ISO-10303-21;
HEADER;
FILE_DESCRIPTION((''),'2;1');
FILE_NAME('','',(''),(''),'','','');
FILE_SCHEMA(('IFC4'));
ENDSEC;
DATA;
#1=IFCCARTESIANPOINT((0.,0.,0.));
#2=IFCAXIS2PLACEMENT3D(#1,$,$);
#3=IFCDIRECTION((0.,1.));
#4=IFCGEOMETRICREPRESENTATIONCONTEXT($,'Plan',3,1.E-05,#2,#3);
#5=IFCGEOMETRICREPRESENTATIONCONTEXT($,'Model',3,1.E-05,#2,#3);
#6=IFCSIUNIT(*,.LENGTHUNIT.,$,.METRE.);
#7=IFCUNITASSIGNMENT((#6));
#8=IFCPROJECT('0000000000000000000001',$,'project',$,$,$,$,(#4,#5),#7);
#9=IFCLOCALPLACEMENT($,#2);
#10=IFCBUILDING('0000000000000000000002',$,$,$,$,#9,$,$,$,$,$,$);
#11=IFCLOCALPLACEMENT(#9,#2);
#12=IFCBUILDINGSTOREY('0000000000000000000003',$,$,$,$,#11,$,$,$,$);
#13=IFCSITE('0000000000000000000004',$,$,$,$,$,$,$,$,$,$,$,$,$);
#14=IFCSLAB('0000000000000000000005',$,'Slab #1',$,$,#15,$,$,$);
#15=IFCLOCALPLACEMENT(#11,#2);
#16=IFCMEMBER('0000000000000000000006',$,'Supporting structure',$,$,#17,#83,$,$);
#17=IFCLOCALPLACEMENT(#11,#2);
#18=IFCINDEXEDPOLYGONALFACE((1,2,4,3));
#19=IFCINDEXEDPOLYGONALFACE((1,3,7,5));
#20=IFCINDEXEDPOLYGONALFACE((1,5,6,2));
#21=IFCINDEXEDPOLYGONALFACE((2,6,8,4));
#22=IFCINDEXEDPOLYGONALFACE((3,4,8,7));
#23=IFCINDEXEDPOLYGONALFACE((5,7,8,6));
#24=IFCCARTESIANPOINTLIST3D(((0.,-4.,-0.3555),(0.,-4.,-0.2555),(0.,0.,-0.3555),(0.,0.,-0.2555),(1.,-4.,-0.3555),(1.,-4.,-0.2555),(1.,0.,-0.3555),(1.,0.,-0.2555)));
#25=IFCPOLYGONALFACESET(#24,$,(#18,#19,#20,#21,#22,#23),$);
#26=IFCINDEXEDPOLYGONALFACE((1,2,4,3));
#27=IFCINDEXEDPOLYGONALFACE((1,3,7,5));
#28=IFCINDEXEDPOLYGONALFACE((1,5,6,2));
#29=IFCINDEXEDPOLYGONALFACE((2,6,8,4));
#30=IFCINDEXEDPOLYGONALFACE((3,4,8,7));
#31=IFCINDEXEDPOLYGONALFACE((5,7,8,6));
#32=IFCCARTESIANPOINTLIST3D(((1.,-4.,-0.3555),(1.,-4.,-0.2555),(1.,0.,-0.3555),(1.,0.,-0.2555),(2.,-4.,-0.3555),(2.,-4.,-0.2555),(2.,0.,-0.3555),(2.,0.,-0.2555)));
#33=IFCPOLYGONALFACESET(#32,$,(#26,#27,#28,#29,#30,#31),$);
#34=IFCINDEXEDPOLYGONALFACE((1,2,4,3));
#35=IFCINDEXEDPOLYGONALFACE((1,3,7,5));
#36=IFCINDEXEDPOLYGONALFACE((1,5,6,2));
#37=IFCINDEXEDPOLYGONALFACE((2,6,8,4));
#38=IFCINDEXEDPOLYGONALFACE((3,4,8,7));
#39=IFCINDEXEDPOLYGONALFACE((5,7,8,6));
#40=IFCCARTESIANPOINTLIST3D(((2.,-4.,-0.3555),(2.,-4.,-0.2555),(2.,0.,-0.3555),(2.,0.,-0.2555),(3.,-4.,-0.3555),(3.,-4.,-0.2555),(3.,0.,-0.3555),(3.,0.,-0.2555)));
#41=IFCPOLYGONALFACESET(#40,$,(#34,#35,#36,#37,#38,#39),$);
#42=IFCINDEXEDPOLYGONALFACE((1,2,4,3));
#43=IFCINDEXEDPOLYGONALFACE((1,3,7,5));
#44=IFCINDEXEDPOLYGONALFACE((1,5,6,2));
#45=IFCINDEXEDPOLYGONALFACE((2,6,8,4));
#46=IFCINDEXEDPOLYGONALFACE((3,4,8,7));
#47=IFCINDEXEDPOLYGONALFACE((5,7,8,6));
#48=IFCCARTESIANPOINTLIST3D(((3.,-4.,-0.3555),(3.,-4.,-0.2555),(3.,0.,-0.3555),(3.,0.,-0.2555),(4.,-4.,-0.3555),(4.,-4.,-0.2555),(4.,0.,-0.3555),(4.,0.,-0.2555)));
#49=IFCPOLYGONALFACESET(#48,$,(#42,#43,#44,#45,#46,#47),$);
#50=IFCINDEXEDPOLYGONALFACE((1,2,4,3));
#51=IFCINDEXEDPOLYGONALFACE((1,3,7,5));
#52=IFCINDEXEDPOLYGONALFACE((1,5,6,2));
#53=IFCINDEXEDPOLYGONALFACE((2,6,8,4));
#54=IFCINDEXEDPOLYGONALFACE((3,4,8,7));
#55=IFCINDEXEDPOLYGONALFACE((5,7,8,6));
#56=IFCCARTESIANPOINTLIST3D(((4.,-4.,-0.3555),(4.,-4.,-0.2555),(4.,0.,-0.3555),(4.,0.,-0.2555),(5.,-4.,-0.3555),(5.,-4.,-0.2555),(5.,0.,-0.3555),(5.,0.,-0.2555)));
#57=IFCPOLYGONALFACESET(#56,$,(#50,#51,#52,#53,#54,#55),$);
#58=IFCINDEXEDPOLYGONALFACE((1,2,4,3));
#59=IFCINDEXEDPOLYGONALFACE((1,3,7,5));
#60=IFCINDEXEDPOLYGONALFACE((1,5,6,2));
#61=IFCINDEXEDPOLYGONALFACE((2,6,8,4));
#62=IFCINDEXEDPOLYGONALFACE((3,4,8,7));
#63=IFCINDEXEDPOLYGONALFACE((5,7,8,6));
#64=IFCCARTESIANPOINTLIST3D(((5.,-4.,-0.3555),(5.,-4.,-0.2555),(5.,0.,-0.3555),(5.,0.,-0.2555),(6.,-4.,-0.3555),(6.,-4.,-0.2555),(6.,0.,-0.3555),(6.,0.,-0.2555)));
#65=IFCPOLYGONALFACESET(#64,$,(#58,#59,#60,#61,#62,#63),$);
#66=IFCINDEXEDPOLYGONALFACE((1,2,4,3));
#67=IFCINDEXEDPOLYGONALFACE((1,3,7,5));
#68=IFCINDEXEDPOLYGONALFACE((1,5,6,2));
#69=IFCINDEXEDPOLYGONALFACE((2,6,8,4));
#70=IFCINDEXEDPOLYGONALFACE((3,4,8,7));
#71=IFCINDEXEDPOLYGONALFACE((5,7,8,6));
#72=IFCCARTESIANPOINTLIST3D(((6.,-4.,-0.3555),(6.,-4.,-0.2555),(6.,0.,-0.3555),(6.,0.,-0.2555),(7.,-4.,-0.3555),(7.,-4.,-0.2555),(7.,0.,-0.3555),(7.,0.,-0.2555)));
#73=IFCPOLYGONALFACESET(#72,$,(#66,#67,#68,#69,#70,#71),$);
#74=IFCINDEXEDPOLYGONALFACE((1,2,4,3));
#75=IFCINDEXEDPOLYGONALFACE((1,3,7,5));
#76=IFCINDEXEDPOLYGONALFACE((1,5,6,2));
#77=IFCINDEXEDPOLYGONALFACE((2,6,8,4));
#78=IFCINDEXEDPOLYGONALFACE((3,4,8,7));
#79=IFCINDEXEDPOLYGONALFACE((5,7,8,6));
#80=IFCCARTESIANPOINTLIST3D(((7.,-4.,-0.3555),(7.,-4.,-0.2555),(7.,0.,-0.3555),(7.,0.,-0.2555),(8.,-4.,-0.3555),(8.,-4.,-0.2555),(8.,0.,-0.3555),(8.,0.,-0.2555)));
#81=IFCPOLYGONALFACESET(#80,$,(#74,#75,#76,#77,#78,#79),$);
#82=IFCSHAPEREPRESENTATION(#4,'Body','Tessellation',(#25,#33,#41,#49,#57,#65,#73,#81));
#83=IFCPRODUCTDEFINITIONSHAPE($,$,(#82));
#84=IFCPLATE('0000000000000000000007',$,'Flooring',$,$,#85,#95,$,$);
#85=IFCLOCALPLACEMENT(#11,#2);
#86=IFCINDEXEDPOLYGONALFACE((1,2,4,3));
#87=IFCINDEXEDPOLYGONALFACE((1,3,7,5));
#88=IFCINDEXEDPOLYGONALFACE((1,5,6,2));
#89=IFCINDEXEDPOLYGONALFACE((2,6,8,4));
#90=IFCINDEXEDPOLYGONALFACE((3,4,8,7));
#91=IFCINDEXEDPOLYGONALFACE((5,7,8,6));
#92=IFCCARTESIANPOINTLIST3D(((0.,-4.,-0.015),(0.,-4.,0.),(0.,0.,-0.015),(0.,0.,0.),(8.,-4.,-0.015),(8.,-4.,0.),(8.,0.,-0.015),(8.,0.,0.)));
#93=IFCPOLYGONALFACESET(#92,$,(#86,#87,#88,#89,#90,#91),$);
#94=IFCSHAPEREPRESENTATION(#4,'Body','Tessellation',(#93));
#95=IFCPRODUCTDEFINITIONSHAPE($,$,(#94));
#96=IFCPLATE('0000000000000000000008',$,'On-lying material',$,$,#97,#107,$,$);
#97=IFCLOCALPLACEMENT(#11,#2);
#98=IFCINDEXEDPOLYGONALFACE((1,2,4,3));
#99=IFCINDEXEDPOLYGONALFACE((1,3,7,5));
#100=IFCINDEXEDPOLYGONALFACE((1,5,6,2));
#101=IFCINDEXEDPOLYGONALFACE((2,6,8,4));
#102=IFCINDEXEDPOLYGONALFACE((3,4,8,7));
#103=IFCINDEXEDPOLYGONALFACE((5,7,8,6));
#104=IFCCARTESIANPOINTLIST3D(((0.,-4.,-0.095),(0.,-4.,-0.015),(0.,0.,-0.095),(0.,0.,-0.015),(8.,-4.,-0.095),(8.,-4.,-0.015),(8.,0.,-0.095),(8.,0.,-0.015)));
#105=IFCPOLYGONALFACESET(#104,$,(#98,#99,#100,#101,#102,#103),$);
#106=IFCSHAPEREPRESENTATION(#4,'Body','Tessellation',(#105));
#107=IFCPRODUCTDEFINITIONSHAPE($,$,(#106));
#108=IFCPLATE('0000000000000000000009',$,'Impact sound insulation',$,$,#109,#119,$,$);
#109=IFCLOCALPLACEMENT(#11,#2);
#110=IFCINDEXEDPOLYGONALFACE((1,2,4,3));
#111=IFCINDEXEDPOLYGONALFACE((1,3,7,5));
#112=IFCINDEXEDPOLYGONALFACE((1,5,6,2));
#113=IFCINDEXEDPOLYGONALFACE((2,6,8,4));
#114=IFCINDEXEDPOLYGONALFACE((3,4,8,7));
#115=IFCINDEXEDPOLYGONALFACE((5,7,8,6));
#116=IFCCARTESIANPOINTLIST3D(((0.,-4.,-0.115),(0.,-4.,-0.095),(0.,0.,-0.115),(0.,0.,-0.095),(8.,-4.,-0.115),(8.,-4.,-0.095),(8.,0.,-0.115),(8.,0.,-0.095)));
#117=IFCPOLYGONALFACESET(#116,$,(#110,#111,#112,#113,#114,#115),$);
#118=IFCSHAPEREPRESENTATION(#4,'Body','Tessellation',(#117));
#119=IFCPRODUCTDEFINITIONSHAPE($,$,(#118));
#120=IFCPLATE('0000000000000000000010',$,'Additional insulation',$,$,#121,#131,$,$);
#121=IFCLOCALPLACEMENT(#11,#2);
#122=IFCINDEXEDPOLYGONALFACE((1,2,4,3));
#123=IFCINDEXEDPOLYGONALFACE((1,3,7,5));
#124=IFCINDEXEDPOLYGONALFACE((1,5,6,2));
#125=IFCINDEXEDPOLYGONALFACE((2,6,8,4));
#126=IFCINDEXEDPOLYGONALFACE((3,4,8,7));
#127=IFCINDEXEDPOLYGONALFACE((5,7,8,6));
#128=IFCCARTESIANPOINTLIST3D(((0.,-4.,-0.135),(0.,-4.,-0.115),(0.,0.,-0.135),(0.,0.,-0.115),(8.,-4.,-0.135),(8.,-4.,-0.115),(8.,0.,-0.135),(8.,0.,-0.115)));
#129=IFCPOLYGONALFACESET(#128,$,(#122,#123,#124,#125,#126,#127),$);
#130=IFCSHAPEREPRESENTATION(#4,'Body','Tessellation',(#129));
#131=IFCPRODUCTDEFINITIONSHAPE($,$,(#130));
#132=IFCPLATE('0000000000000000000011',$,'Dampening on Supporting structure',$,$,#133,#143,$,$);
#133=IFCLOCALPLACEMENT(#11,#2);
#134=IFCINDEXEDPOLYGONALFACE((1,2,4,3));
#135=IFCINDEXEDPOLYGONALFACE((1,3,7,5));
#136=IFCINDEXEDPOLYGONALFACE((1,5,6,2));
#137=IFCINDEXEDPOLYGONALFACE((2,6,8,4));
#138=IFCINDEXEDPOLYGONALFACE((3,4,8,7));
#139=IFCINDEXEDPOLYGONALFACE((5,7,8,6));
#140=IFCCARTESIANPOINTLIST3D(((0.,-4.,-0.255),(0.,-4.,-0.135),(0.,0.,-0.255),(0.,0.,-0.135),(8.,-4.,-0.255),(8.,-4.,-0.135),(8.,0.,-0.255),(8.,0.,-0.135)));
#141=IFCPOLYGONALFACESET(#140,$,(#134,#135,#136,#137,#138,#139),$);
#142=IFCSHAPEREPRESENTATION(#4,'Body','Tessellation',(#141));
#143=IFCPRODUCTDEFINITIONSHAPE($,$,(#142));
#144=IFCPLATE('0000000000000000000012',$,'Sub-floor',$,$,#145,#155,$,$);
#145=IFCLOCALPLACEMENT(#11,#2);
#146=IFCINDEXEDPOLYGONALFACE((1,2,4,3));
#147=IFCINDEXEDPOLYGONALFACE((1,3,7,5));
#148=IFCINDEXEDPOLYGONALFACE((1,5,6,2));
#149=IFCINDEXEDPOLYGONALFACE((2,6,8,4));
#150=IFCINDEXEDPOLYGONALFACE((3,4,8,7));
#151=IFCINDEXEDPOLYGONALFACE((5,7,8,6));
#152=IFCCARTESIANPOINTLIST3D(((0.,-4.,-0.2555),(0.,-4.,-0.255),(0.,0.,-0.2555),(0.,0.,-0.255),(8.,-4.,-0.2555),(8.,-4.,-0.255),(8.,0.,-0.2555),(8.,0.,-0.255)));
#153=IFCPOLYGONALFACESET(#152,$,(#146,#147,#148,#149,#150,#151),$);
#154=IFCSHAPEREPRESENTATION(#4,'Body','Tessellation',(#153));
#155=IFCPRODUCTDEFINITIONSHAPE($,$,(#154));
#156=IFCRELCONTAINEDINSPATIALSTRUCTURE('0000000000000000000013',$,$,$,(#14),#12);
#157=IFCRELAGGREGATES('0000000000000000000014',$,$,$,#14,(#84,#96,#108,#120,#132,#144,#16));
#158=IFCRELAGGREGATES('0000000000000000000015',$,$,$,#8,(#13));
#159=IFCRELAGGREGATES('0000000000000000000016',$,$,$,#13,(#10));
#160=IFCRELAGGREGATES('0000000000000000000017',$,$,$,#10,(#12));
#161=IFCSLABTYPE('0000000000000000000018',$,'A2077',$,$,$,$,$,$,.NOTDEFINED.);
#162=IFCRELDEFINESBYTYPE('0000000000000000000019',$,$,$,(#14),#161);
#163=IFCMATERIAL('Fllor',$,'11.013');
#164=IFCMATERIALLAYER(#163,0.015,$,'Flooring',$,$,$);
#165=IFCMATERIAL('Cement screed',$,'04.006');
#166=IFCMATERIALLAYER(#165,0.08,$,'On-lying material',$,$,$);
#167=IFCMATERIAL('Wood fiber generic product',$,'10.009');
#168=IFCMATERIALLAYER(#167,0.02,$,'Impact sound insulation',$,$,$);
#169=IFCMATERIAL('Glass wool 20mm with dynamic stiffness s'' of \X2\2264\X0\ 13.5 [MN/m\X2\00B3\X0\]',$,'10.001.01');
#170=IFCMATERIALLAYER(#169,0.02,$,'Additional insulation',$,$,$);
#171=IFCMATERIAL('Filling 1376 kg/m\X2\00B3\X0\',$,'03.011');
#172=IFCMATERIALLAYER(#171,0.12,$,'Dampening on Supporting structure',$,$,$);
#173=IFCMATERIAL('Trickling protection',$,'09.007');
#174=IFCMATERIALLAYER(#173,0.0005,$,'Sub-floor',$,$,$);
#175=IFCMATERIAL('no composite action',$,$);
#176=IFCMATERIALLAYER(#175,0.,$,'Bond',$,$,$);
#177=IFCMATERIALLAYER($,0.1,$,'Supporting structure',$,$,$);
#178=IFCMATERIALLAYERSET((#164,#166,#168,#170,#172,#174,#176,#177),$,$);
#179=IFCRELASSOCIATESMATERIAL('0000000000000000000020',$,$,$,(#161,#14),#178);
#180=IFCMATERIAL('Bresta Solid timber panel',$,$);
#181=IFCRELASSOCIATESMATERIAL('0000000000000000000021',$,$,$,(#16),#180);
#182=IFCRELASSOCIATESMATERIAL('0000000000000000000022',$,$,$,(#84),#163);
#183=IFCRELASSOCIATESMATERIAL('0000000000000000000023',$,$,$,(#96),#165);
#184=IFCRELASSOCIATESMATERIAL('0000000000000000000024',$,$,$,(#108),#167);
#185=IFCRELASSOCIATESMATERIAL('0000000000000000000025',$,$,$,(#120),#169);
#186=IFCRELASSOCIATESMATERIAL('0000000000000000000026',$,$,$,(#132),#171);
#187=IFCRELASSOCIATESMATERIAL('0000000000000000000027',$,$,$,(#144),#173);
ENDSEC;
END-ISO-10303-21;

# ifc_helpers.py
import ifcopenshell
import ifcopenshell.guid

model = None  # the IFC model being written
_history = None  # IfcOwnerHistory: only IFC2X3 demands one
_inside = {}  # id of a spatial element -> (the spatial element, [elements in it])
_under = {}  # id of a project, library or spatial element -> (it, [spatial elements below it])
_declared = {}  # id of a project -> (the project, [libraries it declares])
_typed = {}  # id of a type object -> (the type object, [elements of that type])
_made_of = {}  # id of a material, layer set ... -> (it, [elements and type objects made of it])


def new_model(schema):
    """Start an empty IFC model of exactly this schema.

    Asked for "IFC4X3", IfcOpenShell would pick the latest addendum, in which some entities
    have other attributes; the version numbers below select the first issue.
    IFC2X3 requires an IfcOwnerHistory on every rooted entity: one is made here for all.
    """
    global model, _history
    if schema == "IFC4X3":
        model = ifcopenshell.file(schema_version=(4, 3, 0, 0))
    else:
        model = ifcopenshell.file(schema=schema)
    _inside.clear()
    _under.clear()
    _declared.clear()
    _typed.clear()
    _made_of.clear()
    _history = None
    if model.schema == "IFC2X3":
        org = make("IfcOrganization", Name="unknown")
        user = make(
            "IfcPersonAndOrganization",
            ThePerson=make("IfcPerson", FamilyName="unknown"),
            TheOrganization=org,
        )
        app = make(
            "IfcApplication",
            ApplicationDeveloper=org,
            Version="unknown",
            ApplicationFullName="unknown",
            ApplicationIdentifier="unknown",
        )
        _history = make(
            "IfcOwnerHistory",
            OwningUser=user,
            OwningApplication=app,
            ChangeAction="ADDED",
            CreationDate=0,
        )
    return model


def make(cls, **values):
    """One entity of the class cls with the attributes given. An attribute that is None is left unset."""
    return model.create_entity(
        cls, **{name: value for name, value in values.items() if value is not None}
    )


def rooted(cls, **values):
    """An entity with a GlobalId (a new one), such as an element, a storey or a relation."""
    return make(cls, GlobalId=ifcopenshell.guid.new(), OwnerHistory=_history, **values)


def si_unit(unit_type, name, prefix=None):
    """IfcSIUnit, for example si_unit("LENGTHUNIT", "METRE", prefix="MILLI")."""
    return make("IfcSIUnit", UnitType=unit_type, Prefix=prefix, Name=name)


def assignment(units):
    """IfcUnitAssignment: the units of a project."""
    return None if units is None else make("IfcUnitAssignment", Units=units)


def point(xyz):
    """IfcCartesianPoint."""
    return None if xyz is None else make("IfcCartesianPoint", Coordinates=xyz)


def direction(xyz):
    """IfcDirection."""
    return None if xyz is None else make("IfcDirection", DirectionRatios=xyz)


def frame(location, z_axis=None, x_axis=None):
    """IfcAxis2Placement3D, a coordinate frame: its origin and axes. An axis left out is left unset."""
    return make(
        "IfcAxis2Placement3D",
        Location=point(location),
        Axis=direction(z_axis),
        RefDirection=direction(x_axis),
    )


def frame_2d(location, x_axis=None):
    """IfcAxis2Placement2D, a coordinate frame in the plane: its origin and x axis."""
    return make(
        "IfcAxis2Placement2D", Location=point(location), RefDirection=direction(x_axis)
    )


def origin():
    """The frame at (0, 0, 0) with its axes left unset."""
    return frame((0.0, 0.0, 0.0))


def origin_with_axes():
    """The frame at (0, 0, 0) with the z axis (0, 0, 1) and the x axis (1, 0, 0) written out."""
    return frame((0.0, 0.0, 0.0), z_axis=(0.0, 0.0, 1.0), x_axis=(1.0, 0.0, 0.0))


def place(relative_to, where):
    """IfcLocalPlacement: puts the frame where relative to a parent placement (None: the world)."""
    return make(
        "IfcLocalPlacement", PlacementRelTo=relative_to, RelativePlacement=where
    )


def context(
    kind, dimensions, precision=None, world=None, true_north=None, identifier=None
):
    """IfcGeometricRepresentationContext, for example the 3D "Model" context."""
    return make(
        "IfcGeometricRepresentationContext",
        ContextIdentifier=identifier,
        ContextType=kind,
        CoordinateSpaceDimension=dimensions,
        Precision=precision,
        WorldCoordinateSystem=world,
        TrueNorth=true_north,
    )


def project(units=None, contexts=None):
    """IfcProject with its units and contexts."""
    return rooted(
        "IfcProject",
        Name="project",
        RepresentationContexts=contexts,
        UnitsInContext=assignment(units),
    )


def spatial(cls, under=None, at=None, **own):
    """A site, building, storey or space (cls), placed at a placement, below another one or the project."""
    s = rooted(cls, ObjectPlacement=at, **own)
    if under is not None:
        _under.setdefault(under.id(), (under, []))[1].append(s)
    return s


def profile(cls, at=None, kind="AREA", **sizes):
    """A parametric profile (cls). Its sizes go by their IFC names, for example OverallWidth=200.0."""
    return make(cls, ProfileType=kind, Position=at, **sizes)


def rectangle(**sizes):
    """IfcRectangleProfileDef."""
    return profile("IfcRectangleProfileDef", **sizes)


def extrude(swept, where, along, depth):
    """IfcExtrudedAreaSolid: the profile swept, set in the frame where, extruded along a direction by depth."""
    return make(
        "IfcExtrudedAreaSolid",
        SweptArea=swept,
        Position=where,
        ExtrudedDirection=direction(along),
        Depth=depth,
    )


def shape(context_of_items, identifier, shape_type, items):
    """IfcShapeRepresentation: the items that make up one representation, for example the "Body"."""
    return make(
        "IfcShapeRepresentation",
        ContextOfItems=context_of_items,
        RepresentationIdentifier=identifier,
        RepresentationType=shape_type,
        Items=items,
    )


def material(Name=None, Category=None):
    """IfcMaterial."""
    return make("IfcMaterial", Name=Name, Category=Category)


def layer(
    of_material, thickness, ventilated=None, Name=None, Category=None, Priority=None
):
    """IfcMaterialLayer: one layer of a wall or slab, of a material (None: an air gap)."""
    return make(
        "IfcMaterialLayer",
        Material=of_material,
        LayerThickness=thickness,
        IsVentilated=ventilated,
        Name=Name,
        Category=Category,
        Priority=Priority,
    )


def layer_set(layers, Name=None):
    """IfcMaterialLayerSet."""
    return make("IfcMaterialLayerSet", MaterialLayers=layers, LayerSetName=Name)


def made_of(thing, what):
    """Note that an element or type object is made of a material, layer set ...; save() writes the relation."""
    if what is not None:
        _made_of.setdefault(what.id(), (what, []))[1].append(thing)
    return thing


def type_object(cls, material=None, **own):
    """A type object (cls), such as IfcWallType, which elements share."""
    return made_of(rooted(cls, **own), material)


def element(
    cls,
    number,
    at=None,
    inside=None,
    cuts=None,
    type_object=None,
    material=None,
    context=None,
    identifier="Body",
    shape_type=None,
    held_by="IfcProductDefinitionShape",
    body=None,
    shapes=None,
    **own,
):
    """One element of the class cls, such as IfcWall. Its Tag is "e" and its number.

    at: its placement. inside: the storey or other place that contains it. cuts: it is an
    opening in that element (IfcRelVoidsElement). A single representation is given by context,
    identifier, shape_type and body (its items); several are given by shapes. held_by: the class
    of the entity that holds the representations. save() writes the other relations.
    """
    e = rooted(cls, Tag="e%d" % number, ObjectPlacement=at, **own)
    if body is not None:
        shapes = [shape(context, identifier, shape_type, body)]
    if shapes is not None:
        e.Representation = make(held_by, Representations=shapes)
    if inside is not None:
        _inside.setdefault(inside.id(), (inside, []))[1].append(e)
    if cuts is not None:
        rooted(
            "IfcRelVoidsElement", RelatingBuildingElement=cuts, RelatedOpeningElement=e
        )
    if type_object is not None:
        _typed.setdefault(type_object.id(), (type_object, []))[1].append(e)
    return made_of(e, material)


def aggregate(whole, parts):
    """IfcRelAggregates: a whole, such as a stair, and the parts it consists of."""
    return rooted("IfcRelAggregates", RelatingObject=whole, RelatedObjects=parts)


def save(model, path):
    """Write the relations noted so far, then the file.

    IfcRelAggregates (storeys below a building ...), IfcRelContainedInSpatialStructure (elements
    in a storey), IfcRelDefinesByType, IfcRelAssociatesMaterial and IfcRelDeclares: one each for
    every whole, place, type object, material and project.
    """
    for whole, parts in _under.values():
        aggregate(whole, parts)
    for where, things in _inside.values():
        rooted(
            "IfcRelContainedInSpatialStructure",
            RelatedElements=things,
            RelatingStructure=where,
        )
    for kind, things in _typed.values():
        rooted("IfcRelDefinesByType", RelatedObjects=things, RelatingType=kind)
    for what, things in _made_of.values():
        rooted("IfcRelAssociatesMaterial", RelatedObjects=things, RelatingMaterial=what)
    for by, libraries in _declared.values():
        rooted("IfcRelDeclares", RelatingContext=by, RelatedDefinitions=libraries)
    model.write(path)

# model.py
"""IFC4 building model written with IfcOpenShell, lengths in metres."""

from ifc_helpers import new_model, si_unit, direction, frame, frame_2d, origin, origin_with_axes, place, context, project, spatial, rectangle, extrude, material, layer, layer_set, type_object, element, aggregate, save


model = new_model("IFC4")

# Units and contexts
plan_context = context("Plan", 3, precision=1e-05, world=origin(), true_north=direction((0.0, 1.0)))
model_context = context("Model", 3, precision=1e-05, world=origin(), true_north=direction((0.0, 1.0)))
ifc_project = project(units=[si_unit("LENGTHUNIT", "METRE")], contexts=[plan_context, model_context])

# Site, building, storey
site = spatial("IfcSite", under=ifc_project)
building_placement = place(None, origin())
building = spatial("IfcBuilding", under=site, at=building_placement)
storey_placement = place(building_placement, origin())
storey = spatial("IfcBuildingStorey", under=building, at=storey_placement)

# Slab, member, plates
ifc_material_1 = material(Name="Fllor", Category="11.013")
ifc_layer_1 = layer(ifc_material_1, 0.015, Name="Flooring")
ifc_material_2 = material(Name="Cement screed", Category="04.006")
ifc_layer_2 = layer(ifc_material_2, 0.08, Name="On-lying material")
ifc_material_3 = material(Name="Wood fiber generic product", Category="10.009")
ifc_layer_3 = layer(ifc_material_3, 0.02, Name="Impact sound insulation")
ifc_material_4 = material(Name="Glass wool 20mm with dynamic stiffness s' of ≤ 13.5 [MN/m³]", Category="10.001.01")
ifc_layer_4 = layer(ifc_material_4, 0.02, Name="Additional insulation")
ifc_material_5 = material(Name="Filling 1376 kg/m³", Category="03.011")
ifc_layer_5 = layer(ifc_material_5, 0.12, Name="Dampening on Supporting structure")
ifc_material_6 = material(Name="Trickling protection", Category="09.007")
ifc_layer_6 = layer(ifc_material_6, 0.0005, Name="Sub-floor")
ifc_material_7 = material(Name="no composite action")
ifc_layer_7 = layer(ifc_material_7, 0.0, Name="Bond")
ifc_layer_8 = layer(None, 0.1, Name="Supporting structure")
ifc_layer_set = layer_set([ifc_layer_1, ifc_layer_2, ifc_layer_3, ifc_layer_4, ifc_layer_5, ifc_layer_6, ifc_layer_7, ifc_layer_8])
slab_type = type_object("IfcSlabType", Name="A2077", PredefinedType="NOTDEFINED", material=ifc_layer_set)
slab_placement = place(None, frame((0.0, 0.0, 0.0), z_axis=(0.0, 0.0, -1.0), x_axis=(1.0, 0.0, 0.0)))
slab = element("IfcSlab", 1, at=slab_placement, inside=storey, type_object=slab_type, material=ifc_layer_set, Name="Slab #1")
ifc_material_8 = material(Name="Bresta Solid timber panel")
member_placement = place(slab_placement, origin())
member = element("IfcMember", 2, at=member_placement, material=ifc_material_8, Name="Supporting structure", context=plan_context, shape_type="SweptSolid", body=[
    extrude(rectangle(XDim=1.0, YDim=0.1, at=frame_2d((0.5, 0.05), x_axis=(1.0, 0.0))), frame((0.0, 4.0, 0.2555), z_axis=(0.0, -1.0, 0.0), x_axis=(1.0, 0.0, 0.0)), (0.0, 0.0, 1.0), 4.0),
    extrude(rectangle(XDim=1.0, YDim=0.1, at=frame_2d((0.5, 0.05), x_axis=(1.0, 0.0))), frame((1.0, 4.0, 0.2555), z_axis=(0.0, -1.0, 0.0), x_axis=(1.0, 0.0, 0.0)), (0.0, 0.0, 1.0), 4.0),
    extrude(rectangle(XDim=1.0, YDim=0.1, at=frame_2d((0.5, 0.05), x_axis=(1.0, 0.0))), frame((2.0, 4.0, 0.2555), z_axis=(0.0, -1.0, 0.0), x_axis=(1.0, 0.0, 0.0)), (0.0, 0.0, 1.0), 4.0),
    extrude(rectangle(XDim=1.0, YDim=0.1, at=frame_2d((0.5, 0.05), x_axis=(1.0, 0.0))), frame((3.0, 4.0, 0.2555), z_axis=(0.0, -1.0, 0.0), x_axis=(1.0, 0.0, 0.0)), (0.0, 0.0, 1.0), 4.0),
    extrude(rectangle(XDim=1.0, YDim=0.1, at=frame_2d((0.5, 0.05), x_axis=(1.0, 0.0))), frame((4.0, 4.0, 0.2555), z_axis=(0.0, -1.0, 0.0), x_axis=(1.0, 0.0, 0.0)), (0.0, 0.0, 1.0), 4.0),
    extrude(rectangle(XDim=1.0, YDim=0.1, at=frame_2d((0.5, 0.05), x_axis=(1.0, 0.0))), frame((5.0, 4.0, 0.2555), z_axis=(0.0, -1.0, 0.0), x_axis=(1.0, 0.0, 0.0)), (0.0, 0.0, 1.0), 4.0),
    extrude(rectangle(XDim=1.0, YDim=0.1, at=frame_2d((0.5, 0.05), x_axis=(1.0, 0.0))), frame((6.0, 4.0, 0.2555), z_axis=(0.0, -1.0, 0.0), x_axis=(1.0, 0.0, 0.0)), (0.0, 0.0, 1.0), 4.0),
    extrude(rectangle(XDim=1.0, YDim=0.1, at=frame_2d((0.5, 0.05), x_axis=(1.0, 0.0))), frame((7.0, 4.0, 0.2555), z_axis=(0.0, -1.0, 0.0), x_axis=(1.0, 0.0, 0.0)), (0.0, 0.0, 1.0), 4.0),
])
plate_1_placement = place(slab_placement, origin())
plate_1 = element("IfcPlate", 3, at=plate_1_placement, material=ifc_material_1, Name="Flooring", context=plan_context, shape_type="SweptSolid", body=[
    extrude(rectangle(XDim=8.0, YDim=4.0, at=frame_2d((4.0, 2.0), x_axis=(1.0, 0.0))), origin_with_axes(), (0.0, 0.0, 1.0), 0.015),
])
plate_2_placement = place(slab_placement, origin())
plate_2 = element("IfcPlate", 4, at=plate_2_placement, material=ifc_material_2, Name="On-lying material", context=plan_context, shape_type="SweptSolid", body=[
    extrude(rectangle(XDim=8.0, YDim=4.0, at=frame_2d((4.0, 2.0), x_axis=(1.0, 0.0))), frame((0.0, 0.0, 0.015), z_axis=(0.0, 0.0, 1.0), x_axis=(1.0, 0.0, 0.0)), (0.0, 0.0, 1.0), 0.08),
])
plate_3_placement = place(slab_placement, origin())
plate_3 = element("IfcPlate", 5, at=plate_3_placement, material=ifc_material_3, Name="Impact sound insulation", context=plan_context, shape_type="SweptSolid", body=[
    extrude(rectangle(XDim=8.0, YDim=4.0, at=frame_2d((4.0, 2.0), x_axis=(1.0, 0.0))), frame((0.0, 0.0, 0.095), z_axis=(0.0, 0.0, 1.0), x_axis=(1.0, 0.0, 0.0)), (0.0, 0.0, 1.0), 0.02),
])
plate_4_placement = place(slab_placement, origin())
plate_4 = element("IfcPlate", 6, at=plate_4_placement, material=ifc_material_4, Name="Additional insulation", context=plan_context, shape_type="SweptSolid", body=[
    extrude(rectangle(XDim=8.0, YDim=4.0, at=frame_2d((4.0, 2.0), x_axis=(1.0, 0.0))), frame((0.0, 0.0, 0.115), z_axis=(0.0, 0.0, 1.0), x_axis=(1.0, 0.0, 0.0)), (0.0, 0.0, 1.0), 0.02),
])
plate_5_placement = place(slab_placement, origin())
plate_5 = element("IfcPlate", 7, at=plate_5_placement, material=ifc_material_5, Name="Dampening on Supporting structure", context=plan_context, shape_type="SweptSolid", body=[
    extrude(rectangle(XDim=8.0, YDim=4.0, at=frame_2d((4.0, 2.0), x_axis=(1.0, 0.0))), frame((0.0, 0.0, 0.135), z_axis=(0.0, 0.0, 1.0), x_axis=(1.0, 0.0, 0.0)), (0.0, 0.0, 1.0), 0.12),
])
plate_6_placement = place(slab_placement, origin())
plate_6 = element("IfcPlate", 8, at=plate_6_placement, material=ifc_material_6, Name="Sub-floor", context=plan_context, shape_type="SweptSolid", body=[
    extrude(rectangle(XDim=8.0, YDim=4.0, at=frame_2d((4.0, 2.0), x_axis=(1.0, 0.0))), frame((0.0, 0.0, 0.255), z_axis=(0.0, 0.0, 1.0), x_axis=(1.0, 0.0, 0.0)), (0.0, 0.0, 1.0), 0.0005),
])
aggregate(slab, [plate_1, plate_2, plate_3, plate_4, plate_5, plate_6, member])

save(model, "model.ifc")
